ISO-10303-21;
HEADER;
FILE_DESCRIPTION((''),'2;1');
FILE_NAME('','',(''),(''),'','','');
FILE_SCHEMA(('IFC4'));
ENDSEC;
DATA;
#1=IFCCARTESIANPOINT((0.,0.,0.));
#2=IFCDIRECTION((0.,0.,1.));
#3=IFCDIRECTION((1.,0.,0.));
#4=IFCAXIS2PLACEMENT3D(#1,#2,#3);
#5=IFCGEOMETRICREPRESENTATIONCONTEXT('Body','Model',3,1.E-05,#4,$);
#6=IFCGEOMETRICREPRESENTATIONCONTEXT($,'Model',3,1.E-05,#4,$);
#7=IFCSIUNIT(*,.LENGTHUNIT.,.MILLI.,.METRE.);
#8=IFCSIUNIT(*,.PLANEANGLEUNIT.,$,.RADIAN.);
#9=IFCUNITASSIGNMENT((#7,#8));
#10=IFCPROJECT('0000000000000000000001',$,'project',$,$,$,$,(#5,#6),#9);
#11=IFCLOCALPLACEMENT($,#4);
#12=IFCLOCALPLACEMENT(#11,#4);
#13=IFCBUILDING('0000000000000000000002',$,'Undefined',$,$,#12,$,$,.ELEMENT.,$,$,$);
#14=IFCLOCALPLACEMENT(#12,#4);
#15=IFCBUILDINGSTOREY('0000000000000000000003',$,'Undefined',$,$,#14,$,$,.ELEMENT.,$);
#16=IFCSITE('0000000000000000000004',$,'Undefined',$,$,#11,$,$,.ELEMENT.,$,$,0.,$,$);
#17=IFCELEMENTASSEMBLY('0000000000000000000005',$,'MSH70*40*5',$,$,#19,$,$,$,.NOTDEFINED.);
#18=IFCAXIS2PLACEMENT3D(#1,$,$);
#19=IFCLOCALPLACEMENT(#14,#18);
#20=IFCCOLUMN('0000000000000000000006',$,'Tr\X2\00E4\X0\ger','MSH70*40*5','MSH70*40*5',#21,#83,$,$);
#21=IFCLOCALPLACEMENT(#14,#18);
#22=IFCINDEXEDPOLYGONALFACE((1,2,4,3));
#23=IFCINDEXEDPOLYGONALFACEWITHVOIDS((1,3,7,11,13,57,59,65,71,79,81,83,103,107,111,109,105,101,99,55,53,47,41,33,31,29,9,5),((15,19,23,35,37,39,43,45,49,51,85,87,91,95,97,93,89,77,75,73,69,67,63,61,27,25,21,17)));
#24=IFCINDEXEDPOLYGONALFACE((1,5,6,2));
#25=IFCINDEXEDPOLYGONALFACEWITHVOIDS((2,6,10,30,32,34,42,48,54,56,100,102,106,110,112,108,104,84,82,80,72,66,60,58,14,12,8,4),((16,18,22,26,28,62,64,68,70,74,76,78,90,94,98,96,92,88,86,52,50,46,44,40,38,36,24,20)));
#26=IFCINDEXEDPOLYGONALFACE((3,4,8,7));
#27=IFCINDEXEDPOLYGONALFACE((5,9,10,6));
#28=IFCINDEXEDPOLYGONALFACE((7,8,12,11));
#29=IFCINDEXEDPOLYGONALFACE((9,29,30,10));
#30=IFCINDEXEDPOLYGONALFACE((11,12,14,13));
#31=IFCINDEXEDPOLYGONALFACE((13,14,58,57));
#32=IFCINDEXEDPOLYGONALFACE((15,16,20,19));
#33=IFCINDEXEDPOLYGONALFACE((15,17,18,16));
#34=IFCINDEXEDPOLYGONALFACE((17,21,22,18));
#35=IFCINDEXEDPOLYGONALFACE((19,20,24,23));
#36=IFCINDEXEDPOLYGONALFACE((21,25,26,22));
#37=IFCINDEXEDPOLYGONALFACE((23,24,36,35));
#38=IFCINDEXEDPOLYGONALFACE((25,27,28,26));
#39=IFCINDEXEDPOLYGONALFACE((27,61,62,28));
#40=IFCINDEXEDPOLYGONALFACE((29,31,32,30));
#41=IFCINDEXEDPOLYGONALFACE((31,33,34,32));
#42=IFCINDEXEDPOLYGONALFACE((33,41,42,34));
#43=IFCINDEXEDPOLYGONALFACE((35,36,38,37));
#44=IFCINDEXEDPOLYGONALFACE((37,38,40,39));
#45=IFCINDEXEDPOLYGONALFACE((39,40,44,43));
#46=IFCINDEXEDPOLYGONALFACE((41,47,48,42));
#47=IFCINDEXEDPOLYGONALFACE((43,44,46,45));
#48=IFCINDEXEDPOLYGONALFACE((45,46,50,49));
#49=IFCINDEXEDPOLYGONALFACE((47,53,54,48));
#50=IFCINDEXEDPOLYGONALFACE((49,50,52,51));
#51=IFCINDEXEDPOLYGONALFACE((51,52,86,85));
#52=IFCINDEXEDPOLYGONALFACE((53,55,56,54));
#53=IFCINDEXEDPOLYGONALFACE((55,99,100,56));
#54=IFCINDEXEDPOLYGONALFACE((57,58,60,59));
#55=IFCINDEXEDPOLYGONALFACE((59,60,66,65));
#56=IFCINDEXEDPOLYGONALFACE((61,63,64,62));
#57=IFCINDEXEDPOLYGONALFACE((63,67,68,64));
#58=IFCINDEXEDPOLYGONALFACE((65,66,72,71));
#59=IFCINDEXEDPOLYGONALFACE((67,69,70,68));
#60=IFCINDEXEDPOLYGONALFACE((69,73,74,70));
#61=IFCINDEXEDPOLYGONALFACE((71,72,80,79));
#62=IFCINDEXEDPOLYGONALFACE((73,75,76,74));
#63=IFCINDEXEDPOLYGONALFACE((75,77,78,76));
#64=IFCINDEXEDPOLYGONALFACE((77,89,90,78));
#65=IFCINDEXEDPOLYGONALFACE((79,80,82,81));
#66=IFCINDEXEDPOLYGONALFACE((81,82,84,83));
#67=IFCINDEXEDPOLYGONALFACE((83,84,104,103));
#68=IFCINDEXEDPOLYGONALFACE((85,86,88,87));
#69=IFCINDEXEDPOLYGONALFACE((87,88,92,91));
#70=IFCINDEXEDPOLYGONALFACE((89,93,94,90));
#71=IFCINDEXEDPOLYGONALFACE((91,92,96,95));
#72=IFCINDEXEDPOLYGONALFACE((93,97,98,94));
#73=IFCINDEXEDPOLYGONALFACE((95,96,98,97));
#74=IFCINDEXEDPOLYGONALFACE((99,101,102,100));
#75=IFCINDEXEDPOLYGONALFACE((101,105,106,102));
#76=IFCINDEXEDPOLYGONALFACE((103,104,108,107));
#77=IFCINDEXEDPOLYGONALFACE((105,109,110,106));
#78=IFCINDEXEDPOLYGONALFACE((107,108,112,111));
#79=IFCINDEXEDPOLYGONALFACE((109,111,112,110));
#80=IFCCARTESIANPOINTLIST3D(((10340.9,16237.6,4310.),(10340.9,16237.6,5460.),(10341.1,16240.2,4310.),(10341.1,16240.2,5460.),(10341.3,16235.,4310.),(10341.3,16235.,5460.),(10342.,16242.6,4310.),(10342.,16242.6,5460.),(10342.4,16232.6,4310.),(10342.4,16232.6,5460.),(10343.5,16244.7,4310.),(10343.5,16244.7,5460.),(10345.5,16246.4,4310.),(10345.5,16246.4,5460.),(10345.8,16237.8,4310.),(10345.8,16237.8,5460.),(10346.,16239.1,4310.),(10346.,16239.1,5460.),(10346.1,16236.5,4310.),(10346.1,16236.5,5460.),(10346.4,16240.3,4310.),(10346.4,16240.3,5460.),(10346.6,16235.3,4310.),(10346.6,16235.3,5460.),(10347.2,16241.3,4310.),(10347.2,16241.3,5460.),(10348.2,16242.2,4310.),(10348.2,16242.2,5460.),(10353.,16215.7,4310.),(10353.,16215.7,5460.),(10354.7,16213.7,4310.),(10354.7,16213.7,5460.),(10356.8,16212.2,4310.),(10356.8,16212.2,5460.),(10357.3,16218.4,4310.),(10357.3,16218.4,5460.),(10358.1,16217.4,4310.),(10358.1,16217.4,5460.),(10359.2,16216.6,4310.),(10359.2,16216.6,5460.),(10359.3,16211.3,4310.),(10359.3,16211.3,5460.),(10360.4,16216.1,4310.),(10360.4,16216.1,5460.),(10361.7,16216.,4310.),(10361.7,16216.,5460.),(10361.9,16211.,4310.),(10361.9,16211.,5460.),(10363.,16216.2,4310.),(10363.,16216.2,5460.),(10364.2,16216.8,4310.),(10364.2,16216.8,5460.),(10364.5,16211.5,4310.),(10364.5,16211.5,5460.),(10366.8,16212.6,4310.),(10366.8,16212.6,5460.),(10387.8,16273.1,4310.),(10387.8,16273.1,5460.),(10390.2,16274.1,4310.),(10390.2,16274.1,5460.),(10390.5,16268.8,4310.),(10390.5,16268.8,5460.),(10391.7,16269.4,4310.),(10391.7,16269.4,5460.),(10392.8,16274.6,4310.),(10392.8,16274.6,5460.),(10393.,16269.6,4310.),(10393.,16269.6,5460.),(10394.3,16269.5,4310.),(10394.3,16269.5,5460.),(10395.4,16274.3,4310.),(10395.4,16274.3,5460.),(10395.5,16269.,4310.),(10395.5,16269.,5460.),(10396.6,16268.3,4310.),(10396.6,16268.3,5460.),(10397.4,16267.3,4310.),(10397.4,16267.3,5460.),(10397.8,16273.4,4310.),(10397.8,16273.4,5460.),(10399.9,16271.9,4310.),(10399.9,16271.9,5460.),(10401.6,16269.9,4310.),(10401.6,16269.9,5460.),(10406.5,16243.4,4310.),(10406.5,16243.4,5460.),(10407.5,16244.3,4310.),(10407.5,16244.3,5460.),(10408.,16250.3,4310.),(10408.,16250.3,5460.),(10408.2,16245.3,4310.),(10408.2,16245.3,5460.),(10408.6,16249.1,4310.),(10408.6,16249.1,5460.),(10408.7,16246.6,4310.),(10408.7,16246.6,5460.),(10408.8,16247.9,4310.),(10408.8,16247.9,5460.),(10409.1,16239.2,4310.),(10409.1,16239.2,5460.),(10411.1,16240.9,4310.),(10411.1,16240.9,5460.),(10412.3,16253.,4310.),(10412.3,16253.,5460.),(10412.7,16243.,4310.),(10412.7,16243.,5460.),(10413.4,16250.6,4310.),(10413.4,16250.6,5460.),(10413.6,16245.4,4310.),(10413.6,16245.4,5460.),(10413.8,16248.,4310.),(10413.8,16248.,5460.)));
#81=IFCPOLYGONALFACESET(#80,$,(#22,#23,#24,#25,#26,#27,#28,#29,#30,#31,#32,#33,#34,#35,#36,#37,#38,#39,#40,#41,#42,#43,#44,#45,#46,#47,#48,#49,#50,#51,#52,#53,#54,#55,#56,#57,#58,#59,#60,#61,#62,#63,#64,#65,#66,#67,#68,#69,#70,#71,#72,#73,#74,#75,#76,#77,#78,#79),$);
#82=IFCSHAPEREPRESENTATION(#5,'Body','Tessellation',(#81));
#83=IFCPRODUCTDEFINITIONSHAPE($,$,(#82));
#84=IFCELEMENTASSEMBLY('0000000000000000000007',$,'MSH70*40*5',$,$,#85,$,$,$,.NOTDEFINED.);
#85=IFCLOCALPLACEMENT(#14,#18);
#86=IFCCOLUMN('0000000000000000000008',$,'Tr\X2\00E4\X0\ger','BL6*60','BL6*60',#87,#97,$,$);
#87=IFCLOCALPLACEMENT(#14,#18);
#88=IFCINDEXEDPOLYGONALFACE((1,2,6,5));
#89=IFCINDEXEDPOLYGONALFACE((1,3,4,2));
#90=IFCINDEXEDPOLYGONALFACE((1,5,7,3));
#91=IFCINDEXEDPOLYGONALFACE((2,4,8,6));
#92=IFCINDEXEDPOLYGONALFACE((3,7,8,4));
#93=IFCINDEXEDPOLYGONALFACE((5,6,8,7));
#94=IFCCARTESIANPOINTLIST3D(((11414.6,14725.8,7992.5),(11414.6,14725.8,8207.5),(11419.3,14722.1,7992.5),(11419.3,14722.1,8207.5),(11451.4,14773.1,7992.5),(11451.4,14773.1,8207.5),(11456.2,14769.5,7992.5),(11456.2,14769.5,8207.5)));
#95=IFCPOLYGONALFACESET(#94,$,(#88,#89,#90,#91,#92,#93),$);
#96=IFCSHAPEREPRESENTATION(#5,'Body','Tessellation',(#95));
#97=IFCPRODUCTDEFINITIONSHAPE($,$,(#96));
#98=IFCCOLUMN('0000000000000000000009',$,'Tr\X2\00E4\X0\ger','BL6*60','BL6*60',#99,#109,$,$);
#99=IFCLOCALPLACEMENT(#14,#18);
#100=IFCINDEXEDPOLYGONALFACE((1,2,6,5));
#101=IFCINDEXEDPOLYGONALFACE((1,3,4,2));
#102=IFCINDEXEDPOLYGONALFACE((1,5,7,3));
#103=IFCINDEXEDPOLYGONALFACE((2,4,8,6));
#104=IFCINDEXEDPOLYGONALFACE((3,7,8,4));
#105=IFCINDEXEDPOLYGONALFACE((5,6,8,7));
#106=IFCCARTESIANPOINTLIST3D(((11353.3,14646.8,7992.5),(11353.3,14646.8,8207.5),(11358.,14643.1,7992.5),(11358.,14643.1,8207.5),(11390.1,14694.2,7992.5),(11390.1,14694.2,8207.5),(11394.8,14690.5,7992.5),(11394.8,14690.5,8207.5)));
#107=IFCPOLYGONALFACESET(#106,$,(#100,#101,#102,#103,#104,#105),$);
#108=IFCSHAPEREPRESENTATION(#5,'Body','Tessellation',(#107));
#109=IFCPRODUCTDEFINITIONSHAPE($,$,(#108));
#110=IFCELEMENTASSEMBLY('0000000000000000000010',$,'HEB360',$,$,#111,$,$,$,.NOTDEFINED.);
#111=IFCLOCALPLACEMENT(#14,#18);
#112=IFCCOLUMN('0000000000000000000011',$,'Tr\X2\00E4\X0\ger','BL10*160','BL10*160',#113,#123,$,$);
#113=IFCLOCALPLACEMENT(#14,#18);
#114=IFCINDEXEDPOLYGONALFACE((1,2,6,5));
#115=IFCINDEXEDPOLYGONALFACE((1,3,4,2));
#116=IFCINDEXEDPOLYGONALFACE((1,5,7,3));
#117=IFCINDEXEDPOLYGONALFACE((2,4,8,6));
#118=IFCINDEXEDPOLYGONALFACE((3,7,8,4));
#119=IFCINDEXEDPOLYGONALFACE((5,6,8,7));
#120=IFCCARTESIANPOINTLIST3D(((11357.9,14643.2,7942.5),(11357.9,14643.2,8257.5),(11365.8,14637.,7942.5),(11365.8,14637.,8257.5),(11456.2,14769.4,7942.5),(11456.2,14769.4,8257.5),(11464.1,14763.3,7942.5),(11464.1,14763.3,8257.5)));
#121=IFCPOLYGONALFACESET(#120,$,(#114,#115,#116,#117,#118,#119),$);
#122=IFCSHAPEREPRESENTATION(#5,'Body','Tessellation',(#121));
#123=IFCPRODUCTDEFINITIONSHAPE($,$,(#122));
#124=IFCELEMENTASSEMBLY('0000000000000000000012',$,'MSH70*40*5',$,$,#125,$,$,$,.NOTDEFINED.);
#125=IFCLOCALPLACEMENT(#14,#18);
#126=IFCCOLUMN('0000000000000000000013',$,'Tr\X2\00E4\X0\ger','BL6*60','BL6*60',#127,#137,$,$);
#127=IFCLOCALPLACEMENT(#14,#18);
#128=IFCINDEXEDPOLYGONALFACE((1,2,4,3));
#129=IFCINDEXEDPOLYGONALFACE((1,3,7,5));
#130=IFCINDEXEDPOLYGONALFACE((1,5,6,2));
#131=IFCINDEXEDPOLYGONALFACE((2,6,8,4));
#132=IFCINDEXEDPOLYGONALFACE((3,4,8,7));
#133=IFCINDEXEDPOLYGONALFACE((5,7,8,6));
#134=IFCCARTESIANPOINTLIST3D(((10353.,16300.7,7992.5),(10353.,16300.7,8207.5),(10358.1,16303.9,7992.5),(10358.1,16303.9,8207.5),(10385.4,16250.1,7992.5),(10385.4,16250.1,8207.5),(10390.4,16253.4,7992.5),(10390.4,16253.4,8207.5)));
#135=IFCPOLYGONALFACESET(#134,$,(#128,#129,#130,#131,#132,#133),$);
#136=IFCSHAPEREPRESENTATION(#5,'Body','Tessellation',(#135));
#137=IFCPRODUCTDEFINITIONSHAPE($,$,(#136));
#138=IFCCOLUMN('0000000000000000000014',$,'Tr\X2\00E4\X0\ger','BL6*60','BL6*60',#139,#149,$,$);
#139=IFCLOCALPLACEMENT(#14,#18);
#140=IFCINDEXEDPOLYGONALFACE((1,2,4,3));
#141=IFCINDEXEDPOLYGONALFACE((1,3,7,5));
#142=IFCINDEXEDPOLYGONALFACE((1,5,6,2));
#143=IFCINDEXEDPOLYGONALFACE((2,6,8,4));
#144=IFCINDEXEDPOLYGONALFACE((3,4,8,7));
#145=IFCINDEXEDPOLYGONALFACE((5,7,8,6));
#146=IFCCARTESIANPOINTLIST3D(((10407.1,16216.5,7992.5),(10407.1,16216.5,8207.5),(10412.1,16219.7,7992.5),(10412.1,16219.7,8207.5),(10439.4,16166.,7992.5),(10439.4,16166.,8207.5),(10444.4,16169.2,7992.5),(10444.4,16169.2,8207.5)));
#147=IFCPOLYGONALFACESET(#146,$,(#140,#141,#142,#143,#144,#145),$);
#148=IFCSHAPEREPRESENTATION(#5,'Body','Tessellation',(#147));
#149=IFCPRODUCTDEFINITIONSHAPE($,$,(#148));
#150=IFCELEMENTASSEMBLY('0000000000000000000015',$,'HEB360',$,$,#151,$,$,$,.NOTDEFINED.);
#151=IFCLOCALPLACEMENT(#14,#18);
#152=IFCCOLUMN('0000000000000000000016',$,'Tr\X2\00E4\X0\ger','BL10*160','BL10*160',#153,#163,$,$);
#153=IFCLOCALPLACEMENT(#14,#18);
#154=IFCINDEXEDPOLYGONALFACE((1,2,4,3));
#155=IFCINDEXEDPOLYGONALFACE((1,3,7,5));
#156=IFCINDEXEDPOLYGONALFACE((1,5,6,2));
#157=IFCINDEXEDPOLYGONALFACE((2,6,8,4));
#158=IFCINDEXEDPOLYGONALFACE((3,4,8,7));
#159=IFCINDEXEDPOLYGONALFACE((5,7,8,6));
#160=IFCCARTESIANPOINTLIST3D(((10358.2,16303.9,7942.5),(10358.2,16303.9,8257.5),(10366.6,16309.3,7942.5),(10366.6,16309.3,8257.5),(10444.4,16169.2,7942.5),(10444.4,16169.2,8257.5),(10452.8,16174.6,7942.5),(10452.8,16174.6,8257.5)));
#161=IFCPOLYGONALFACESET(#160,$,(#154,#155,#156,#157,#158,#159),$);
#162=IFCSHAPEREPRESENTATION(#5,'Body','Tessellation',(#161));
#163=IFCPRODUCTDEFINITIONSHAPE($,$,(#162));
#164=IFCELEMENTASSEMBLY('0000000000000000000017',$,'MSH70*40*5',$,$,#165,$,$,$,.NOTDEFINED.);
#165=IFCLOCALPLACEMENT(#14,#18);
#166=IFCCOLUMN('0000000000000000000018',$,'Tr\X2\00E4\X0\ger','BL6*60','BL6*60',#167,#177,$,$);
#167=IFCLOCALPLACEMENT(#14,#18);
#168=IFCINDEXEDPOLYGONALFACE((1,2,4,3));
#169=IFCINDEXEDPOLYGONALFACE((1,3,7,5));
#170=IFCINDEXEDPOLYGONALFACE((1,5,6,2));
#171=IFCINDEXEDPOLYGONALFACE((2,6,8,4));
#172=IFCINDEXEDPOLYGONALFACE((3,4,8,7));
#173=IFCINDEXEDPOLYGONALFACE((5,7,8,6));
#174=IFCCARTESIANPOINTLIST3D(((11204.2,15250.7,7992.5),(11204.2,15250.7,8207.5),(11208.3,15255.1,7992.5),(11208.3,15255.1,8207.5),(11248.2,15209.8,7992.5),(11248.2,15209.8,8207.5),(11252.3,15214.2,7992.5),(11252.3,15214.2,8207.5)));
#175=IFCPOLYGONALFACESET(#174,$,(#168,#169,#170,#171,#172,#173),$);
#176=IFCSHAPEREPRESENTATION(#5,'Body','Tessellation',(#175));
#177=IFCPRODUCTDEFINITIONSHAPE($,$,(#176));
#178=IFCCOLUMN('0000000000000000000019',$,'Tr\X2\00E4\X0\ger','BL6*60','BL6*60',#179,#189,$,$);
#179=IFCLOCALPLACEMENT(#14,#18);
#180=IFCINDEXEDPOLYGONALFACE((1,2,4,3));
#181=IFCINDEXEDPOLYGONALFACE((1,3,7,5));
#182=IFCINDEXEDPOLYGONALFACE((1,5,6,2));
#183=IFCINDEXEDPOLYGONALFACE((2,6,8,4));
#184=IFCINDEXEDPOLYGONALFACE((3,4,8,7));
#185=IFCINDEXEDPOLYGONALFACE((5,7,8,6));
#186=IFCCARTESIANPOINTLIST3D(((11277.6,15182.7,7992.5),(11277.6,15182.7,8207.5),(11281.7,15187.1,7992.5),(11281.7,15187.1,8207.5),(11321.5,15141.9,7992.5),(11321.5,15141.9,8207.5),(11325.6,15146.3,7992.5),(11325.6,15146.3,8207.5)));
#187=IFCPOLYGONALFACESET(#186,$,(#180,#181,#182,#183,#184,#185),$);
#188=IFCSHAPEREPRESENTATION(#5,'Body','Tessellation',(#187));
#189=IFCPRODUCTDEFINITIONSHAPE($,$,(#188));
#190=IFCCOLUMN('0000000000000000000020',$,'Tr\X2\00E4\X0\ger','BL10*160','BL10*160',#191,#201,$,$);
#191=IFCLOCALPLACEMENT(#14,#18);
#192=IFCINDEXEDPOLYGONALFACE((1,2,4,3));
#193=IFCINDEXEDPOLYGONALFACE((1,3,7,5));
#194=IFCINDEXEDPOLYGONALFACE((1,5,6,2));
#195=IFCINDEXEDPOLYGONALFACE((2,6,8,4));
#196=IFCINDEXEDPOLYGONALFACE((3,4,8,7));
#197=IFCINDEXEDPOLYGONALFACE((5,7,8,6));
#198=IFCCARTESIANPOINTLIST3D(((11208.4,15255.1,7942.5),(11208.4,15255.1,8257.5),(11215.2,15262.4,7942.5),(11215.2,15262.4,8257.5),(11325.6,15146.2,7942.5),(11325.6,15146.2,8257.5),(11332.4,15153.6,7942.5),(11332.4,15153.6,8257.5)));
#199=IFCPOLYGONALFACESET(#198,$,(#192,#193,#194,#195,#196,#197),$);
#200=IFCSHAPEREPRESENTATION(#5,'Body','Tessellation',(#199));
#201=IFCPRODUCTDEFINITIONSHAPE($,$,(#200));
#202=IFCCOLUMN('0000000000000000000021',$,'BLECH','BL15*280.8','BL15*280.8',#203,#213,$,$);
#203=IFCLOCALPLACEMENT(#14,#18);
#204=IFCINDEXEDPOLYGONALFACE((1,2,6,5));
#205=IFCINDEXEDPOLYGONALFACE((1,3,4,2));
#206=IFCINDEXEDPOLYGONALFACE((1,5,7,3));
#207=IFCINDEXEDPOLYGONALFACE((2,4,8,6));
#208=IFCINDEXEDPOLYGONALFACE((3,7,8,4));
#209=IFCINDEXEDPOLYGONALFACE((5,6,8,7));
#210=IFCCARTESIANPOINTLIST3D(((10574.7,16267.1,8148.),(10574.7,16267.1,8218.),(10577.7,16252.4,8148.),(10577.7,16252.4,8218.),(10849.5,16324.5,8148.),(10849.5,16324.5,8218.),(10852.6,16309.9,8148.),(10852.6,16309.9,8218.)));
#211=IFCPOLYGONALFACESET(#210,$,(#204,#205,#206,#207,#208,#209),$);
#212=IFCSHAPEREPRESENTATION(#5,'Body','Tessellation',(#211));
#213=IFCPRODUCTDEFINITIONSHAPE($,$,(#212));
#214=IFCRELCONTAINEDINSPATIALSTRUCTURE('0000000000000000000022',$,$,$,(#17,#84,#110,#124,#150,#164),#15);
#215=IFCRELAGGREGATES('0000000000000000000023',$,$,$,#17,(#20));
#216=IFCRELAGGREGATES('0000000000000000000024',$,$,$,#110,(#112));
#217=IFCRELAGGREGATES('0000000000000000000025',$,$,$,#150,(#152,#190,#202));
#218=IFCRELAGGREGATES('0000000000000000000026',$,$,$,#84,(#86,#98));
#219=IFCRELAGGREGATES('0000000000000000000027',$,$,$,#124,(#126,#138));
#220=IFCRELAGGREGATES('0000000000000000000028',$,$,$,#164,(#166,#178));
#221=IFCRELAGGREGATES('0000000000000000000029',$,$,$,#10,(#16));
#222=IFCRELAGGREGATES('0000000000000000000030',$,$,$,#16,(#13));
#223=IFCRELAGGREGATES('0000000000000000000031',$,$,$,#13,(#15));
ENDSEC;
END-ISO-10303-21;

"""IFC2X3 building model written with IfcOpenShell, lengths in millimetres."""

from ifc_helpers import new_model, si_unit, frame, origin_with_axes, origin_2d_with_axis, place, context, project, spatial, rectangle, hollow_rectangle, extrude, element, aggregate, save


model = new_model("IFC2X3")

# Units and contexts
model_context_1 = context("Model", 3, precision=1e-05, world=origin_with_axes(), identifier="Body")
model_context_2 = context("Model", 3, precision=1e-05, world=origin_with_axes())
ifc_project = project(units=[si_unit("LENGTHUNIT", "METRE", prefix="MILLI"), si_unit("PLANEANGLEUNIT", "RADIAN")], contexts=[model_context_1, model_context_2])

# Site, building, storey
site_placement = place(None, origin_with_axes())
site = spatial("IfcSite", under=ifc_project, at=site_placement, Name="Undefined", CompositionType="ELEMENT", RefElevation=0.0)
building_placement = place(site_placement, origin_with_axes())
building = spatial("IfcBuilding", under=site, at=building_placement, Name="Undefined", CompositionType="ELEMENT")
storey_placement = place(building_placement, origin_with_axes())
storey = spatial("IfcBuildingStorey", under=building, at=storey_placement, Name="Undefined", CompositionType="ELEMENT")

# Element assembly
assembly_1 = element("IfcElementAssembly", 1, inside=storey, Name="MSH70*40*5", PredefinedType="NOTDEFINED")

# Column
column_1_placement = place(storey_placement, frame((10377.3, 16242.8, 4310.0), z_axis=(0.0, 0.0, 1.0), x_axis=(1.0, 0.0, 0.0)))
column_1 = element("IfcColumn", 2, at=column_1_placement, Name="Träger", Description="MSH70*40*5", ObjectType="MSH70*40*5", context=model_context_1, shape_type="SweptSolid", body=[
    extrude(hollow_rectangle(XDim=40.0, YDim=70.0, WallThickness=5.0, InnerFilletRadius=5.0, OuterFilletRadius=10.0, at=origin_2d_with_axis()), frame((0.0, 0.0, 1150.0), z_axis=(0.0, 0.0, -1.0), x_axis=(0.532876, -0.846193, 0.0)), (0.0, 0.0, 1.0), 1150.0),
])
aggregate(assembly_1, [column_1])

# Element assembly, columns
assembly_2 = element("IfcElementAssembly", 3, inside=storey, Name="MSH70*40*5", PredefinedType="NOTDEFINED")
column_2_placement = place(storey_placement, frame((11435.4, 14747.6, 7992.5), z_axis=(0.0, 0.0, 1.0), x_axis=(1.0, 0.0, 0.0)))
column_2 = element("IfcColumn", 4, at=column_2_placement, Name="Träger", Description="BL6*60", ObjectType="BL6*60", context=model_context_1, shape_type="SweptSolid", body=[
    extrude(rectangle(XDim=6.0, YDim=60.0, at=origin_2d_with_axis()), frame((0.0, 0.0, 215.0), z_axis=(0.0, 0.0, -1.0), x_axis=(-0.789084, 0.614285, 0.0)), (0.0, 0.0, 1.0), 215.0),
])
column_3_placement = place(storey_placement, frame((11374.0, 14668.6, 7992.5), z_axis=(0.0, 0.0, 1.0), x_axis=(1.0, 0.0, 0.0)))
column_3 = element("IfcColumn", 5, at=column_3_placement, Name="Träger", Description="BL6*60", ObjectType="BL6*60", context=model_context_1, shape_type="SweptSolid", body=[
    extrude(rectangle(XDim=6.0, YDim=60.0, at=origin_2d_with_axis()), frame((0.0, 0.0, 215.0), z_axis=(0.0, 0.0, -1.0), x_axis=(-0.789084, 0.614285, 0.0)), (0.0, 0.0, 1.0), 215.0),
])

# Element assembly, column
assembly_3 = element("IfcElementAssembly", 6, inside=storey, Name="HEB360", PredefinedType="NOTDEFINED")
column_4_placement = place(storey_placement, frame((11411.0, 14703.2, 7942.5), z_axis=(0.0, 0.0, 1.0), x_axis=(1.0, 0.0, 0.0)))
column_4 = element("IfcColumn", 7, at=column_4_placement, Name="Träger", Description="BL10*160", ObjectType="BL10*160", context=model_context_1, shape_type="SweptSolid", body=[
    extrude(rectangle(XDim=10.0, YDim=160.0, at=origin_2d_with_axis()), frame((0.0, 0.0, 315.0), z_axis=(0.0, 0.0, -1.0), x_axis=(-0.789084, 0.614285, 0.0)), (0.0, 0.0, 1.0), 315.0),
])
aggregate(assembly_3, [column_4])

# Element assembly, columns
assembly_4 = element("IfcElementAssembly", 8, inside=storey, Name="MSH70*40*5", PredefinedType="NOTDEFINED")
column_5_placement = place(storey_placement, frame((10371.7, 16277.0, 7992.5), z_axis=(0.0, 0.0, 1.0), x_axis=(1.0, 0.0, 0.0)))
column_5 = element("IfcColumn", 9, at=column_5_placement, Name="Träger", Description="BL6*60", ObjectType="BL6*60", context=model_context_1, shape_type="SweptSolid", body=[
    extrude(rectangle(XDim=6.0, YDim=60.0, at=origin_2d_with_axis()), frame((0.0, 0.0, 215.0), z_axis=(0.0, 0.0, -1.0), x_axis=(-0.842358, -0.538918, 0.0)), (0.0, 0.0, 1.0), 215.0),
])
column_6_placement = place(storey_placement, frame((10425.8, 16192.9, 7992.5), z_axis=(0.0, 0.0, 1.0), x_axis=(1.0, 0.0, 0.0)))
column_6 = element("IfcColumn", 10, at=column_6_placement, Name="Träger", Description="BL6*60", ObjectType="BL6*60", context=model_context_1, shape_type="SweptSolid", body=[
    extrude(rectangle(XDim=6.0, YDim=60.0, at=origin_2d_with_axis()), frame((0.0, 0.0, 215.0), z_axis=(0.0, 0.0, -1.0), x_axis=(-0.842358, -0.538918, 0.0)), (0.0, 0.0, 1.0), 215.0),
])

# Element assembly, column
assembly_5 = element("IfcElementAssembly", 11, inside=storey, Name="HEB360", PredefinedType="NOTDEFINED")
column_7_placement = place(storey_placement, frame((10405.5, 16239.2, 7942.5), z_axis=(0.0, 0.0, 1.0), x_axis=(1.0, 0.0, 0.0)))
column_7 = element("IfcColumn", 12, at=column_7_placement, Name="Träger", Description="BL10*160", ObjectType="BL10*160", context=model_context_1, shape_type="SweptSolid", body=[
    extrude(rectangle(XDim=10.0, YDim=160.0, at=origin_2d_with_axis()), frame((0.0, 0.0, 315.0), z_axis=(0.0, 0.0, -1.0), x_axis=(-0.842358, -0.538918, 0.0)), (0.0, 0.0, 1.0), 315.0),
])

# Element assembly, columns
assembly_6 = element("IfcElementAssembly", 13, inside=storey, Name="MSH70*40*5", PredefinedType="NOTDEFINED")
column_8_placement = place(storey_placement, frame((11228.2, 15232.4, 7992.5), z_axis=(0.0, 0.0, 1.0), x_axis=(1.0, 0.0, 0.0)))
column_8 = element("IfcColumn", 14, at=column_8_placement, Name="Träger", Description="BL6*60", ObjectType="BL6*60", context=model_context_1, shape_type="SweptSolid", body=[
    extrude(rectangle(XDim=6.0, YDim=60.0, at=origin_2d_with_axis()), frame((0.0, 0.0, 215.0), z_axis=(0.0, 0.0, -1.0), x_axis=(-0.68054, -0.732711, 0.0)), (0.0, 0.0, 1.0), 215.0),
])
column_9_placement = place(storey_placement, frame((11301.6, 15164.5, 7992.5), z_axis=(0.0, 0.0, 1.0), x_axis=(1.0, 0.0, 0.0)))
column_9 = element("IfcColumn", 15, at=column_9_placement, Name="Träger", Description="BL6*60", ObjectType="BL6*60", context=model_context_1, shape_type="SweptSolid", body=[
    extrude(rectangle(XDim=6.0, YDim=60.0, at=origin_2d_with_axis()), frame((0.0, 0.0, 215.0), z_axis=(0.0, 0.0, -1.0), x_axis=(-0.68054, -0.732711, 0.0)), (0.0, 0.0, 1.0), 215.0),
])

# Columns
column_10_placement = place(storey_placement, frame((11270.4, 15204.3, 7942.5), z_axis=(0.0, 0.0, 1.0), x_axis=(1.0, 0.0, 0.0)))
column_10 = element("IfcColumn", 16, at=column_10_placement, Name="Träger", Description="BL10*160", ObjectType="BL10*160", context=model_context_1, shape_type="SweptSolid", body=[
    extrude(rectangle(XDim=10.0, YDim=160.0, at=origin_2d_with_axis()), frame((0.0, 0.0, 315.0), z_axis=(0.0, 0.0, -1.0), x_axis=(-0.68054, -0.732711, 0.0)), (0.0, 0.0, 1.0), 315.0),
])
column_11_placement = place(storey_placement, frame((10713.6, 16288.5, 8148.0), z_axis=(0.0, 0.0, 1.0), x_axis=(1.0, 0.0, 0.0)))
column_11 = element("IfcColumn", 17, at=column_11_placement, Name="BLECH", Description="BL15*280.8", ObjectType="BL15*280.8", context=model_context_1, shape_type="SweptSolid", body=[
    extrude(rectangle(XDim=15.0, YDim=280.8, at=origin_2d_with_axis()), frame((0.0, 0.0, 70.0), z_axis=(0.0, 0.0, -1.0), x_axis=(0.204666, -0.978832, 0.0)), (0.0, 0.0, 1.0), 70.0),
])
aggregate(assembly_5, [column_7, column_10, column_11])
aggregate(assembly_2, [column_2, column_3])
aggregate(assembly_4, [column_5, column_6])
aggregate(assembly_6, [column_8, column_9])

save(model, "model.ifc")
